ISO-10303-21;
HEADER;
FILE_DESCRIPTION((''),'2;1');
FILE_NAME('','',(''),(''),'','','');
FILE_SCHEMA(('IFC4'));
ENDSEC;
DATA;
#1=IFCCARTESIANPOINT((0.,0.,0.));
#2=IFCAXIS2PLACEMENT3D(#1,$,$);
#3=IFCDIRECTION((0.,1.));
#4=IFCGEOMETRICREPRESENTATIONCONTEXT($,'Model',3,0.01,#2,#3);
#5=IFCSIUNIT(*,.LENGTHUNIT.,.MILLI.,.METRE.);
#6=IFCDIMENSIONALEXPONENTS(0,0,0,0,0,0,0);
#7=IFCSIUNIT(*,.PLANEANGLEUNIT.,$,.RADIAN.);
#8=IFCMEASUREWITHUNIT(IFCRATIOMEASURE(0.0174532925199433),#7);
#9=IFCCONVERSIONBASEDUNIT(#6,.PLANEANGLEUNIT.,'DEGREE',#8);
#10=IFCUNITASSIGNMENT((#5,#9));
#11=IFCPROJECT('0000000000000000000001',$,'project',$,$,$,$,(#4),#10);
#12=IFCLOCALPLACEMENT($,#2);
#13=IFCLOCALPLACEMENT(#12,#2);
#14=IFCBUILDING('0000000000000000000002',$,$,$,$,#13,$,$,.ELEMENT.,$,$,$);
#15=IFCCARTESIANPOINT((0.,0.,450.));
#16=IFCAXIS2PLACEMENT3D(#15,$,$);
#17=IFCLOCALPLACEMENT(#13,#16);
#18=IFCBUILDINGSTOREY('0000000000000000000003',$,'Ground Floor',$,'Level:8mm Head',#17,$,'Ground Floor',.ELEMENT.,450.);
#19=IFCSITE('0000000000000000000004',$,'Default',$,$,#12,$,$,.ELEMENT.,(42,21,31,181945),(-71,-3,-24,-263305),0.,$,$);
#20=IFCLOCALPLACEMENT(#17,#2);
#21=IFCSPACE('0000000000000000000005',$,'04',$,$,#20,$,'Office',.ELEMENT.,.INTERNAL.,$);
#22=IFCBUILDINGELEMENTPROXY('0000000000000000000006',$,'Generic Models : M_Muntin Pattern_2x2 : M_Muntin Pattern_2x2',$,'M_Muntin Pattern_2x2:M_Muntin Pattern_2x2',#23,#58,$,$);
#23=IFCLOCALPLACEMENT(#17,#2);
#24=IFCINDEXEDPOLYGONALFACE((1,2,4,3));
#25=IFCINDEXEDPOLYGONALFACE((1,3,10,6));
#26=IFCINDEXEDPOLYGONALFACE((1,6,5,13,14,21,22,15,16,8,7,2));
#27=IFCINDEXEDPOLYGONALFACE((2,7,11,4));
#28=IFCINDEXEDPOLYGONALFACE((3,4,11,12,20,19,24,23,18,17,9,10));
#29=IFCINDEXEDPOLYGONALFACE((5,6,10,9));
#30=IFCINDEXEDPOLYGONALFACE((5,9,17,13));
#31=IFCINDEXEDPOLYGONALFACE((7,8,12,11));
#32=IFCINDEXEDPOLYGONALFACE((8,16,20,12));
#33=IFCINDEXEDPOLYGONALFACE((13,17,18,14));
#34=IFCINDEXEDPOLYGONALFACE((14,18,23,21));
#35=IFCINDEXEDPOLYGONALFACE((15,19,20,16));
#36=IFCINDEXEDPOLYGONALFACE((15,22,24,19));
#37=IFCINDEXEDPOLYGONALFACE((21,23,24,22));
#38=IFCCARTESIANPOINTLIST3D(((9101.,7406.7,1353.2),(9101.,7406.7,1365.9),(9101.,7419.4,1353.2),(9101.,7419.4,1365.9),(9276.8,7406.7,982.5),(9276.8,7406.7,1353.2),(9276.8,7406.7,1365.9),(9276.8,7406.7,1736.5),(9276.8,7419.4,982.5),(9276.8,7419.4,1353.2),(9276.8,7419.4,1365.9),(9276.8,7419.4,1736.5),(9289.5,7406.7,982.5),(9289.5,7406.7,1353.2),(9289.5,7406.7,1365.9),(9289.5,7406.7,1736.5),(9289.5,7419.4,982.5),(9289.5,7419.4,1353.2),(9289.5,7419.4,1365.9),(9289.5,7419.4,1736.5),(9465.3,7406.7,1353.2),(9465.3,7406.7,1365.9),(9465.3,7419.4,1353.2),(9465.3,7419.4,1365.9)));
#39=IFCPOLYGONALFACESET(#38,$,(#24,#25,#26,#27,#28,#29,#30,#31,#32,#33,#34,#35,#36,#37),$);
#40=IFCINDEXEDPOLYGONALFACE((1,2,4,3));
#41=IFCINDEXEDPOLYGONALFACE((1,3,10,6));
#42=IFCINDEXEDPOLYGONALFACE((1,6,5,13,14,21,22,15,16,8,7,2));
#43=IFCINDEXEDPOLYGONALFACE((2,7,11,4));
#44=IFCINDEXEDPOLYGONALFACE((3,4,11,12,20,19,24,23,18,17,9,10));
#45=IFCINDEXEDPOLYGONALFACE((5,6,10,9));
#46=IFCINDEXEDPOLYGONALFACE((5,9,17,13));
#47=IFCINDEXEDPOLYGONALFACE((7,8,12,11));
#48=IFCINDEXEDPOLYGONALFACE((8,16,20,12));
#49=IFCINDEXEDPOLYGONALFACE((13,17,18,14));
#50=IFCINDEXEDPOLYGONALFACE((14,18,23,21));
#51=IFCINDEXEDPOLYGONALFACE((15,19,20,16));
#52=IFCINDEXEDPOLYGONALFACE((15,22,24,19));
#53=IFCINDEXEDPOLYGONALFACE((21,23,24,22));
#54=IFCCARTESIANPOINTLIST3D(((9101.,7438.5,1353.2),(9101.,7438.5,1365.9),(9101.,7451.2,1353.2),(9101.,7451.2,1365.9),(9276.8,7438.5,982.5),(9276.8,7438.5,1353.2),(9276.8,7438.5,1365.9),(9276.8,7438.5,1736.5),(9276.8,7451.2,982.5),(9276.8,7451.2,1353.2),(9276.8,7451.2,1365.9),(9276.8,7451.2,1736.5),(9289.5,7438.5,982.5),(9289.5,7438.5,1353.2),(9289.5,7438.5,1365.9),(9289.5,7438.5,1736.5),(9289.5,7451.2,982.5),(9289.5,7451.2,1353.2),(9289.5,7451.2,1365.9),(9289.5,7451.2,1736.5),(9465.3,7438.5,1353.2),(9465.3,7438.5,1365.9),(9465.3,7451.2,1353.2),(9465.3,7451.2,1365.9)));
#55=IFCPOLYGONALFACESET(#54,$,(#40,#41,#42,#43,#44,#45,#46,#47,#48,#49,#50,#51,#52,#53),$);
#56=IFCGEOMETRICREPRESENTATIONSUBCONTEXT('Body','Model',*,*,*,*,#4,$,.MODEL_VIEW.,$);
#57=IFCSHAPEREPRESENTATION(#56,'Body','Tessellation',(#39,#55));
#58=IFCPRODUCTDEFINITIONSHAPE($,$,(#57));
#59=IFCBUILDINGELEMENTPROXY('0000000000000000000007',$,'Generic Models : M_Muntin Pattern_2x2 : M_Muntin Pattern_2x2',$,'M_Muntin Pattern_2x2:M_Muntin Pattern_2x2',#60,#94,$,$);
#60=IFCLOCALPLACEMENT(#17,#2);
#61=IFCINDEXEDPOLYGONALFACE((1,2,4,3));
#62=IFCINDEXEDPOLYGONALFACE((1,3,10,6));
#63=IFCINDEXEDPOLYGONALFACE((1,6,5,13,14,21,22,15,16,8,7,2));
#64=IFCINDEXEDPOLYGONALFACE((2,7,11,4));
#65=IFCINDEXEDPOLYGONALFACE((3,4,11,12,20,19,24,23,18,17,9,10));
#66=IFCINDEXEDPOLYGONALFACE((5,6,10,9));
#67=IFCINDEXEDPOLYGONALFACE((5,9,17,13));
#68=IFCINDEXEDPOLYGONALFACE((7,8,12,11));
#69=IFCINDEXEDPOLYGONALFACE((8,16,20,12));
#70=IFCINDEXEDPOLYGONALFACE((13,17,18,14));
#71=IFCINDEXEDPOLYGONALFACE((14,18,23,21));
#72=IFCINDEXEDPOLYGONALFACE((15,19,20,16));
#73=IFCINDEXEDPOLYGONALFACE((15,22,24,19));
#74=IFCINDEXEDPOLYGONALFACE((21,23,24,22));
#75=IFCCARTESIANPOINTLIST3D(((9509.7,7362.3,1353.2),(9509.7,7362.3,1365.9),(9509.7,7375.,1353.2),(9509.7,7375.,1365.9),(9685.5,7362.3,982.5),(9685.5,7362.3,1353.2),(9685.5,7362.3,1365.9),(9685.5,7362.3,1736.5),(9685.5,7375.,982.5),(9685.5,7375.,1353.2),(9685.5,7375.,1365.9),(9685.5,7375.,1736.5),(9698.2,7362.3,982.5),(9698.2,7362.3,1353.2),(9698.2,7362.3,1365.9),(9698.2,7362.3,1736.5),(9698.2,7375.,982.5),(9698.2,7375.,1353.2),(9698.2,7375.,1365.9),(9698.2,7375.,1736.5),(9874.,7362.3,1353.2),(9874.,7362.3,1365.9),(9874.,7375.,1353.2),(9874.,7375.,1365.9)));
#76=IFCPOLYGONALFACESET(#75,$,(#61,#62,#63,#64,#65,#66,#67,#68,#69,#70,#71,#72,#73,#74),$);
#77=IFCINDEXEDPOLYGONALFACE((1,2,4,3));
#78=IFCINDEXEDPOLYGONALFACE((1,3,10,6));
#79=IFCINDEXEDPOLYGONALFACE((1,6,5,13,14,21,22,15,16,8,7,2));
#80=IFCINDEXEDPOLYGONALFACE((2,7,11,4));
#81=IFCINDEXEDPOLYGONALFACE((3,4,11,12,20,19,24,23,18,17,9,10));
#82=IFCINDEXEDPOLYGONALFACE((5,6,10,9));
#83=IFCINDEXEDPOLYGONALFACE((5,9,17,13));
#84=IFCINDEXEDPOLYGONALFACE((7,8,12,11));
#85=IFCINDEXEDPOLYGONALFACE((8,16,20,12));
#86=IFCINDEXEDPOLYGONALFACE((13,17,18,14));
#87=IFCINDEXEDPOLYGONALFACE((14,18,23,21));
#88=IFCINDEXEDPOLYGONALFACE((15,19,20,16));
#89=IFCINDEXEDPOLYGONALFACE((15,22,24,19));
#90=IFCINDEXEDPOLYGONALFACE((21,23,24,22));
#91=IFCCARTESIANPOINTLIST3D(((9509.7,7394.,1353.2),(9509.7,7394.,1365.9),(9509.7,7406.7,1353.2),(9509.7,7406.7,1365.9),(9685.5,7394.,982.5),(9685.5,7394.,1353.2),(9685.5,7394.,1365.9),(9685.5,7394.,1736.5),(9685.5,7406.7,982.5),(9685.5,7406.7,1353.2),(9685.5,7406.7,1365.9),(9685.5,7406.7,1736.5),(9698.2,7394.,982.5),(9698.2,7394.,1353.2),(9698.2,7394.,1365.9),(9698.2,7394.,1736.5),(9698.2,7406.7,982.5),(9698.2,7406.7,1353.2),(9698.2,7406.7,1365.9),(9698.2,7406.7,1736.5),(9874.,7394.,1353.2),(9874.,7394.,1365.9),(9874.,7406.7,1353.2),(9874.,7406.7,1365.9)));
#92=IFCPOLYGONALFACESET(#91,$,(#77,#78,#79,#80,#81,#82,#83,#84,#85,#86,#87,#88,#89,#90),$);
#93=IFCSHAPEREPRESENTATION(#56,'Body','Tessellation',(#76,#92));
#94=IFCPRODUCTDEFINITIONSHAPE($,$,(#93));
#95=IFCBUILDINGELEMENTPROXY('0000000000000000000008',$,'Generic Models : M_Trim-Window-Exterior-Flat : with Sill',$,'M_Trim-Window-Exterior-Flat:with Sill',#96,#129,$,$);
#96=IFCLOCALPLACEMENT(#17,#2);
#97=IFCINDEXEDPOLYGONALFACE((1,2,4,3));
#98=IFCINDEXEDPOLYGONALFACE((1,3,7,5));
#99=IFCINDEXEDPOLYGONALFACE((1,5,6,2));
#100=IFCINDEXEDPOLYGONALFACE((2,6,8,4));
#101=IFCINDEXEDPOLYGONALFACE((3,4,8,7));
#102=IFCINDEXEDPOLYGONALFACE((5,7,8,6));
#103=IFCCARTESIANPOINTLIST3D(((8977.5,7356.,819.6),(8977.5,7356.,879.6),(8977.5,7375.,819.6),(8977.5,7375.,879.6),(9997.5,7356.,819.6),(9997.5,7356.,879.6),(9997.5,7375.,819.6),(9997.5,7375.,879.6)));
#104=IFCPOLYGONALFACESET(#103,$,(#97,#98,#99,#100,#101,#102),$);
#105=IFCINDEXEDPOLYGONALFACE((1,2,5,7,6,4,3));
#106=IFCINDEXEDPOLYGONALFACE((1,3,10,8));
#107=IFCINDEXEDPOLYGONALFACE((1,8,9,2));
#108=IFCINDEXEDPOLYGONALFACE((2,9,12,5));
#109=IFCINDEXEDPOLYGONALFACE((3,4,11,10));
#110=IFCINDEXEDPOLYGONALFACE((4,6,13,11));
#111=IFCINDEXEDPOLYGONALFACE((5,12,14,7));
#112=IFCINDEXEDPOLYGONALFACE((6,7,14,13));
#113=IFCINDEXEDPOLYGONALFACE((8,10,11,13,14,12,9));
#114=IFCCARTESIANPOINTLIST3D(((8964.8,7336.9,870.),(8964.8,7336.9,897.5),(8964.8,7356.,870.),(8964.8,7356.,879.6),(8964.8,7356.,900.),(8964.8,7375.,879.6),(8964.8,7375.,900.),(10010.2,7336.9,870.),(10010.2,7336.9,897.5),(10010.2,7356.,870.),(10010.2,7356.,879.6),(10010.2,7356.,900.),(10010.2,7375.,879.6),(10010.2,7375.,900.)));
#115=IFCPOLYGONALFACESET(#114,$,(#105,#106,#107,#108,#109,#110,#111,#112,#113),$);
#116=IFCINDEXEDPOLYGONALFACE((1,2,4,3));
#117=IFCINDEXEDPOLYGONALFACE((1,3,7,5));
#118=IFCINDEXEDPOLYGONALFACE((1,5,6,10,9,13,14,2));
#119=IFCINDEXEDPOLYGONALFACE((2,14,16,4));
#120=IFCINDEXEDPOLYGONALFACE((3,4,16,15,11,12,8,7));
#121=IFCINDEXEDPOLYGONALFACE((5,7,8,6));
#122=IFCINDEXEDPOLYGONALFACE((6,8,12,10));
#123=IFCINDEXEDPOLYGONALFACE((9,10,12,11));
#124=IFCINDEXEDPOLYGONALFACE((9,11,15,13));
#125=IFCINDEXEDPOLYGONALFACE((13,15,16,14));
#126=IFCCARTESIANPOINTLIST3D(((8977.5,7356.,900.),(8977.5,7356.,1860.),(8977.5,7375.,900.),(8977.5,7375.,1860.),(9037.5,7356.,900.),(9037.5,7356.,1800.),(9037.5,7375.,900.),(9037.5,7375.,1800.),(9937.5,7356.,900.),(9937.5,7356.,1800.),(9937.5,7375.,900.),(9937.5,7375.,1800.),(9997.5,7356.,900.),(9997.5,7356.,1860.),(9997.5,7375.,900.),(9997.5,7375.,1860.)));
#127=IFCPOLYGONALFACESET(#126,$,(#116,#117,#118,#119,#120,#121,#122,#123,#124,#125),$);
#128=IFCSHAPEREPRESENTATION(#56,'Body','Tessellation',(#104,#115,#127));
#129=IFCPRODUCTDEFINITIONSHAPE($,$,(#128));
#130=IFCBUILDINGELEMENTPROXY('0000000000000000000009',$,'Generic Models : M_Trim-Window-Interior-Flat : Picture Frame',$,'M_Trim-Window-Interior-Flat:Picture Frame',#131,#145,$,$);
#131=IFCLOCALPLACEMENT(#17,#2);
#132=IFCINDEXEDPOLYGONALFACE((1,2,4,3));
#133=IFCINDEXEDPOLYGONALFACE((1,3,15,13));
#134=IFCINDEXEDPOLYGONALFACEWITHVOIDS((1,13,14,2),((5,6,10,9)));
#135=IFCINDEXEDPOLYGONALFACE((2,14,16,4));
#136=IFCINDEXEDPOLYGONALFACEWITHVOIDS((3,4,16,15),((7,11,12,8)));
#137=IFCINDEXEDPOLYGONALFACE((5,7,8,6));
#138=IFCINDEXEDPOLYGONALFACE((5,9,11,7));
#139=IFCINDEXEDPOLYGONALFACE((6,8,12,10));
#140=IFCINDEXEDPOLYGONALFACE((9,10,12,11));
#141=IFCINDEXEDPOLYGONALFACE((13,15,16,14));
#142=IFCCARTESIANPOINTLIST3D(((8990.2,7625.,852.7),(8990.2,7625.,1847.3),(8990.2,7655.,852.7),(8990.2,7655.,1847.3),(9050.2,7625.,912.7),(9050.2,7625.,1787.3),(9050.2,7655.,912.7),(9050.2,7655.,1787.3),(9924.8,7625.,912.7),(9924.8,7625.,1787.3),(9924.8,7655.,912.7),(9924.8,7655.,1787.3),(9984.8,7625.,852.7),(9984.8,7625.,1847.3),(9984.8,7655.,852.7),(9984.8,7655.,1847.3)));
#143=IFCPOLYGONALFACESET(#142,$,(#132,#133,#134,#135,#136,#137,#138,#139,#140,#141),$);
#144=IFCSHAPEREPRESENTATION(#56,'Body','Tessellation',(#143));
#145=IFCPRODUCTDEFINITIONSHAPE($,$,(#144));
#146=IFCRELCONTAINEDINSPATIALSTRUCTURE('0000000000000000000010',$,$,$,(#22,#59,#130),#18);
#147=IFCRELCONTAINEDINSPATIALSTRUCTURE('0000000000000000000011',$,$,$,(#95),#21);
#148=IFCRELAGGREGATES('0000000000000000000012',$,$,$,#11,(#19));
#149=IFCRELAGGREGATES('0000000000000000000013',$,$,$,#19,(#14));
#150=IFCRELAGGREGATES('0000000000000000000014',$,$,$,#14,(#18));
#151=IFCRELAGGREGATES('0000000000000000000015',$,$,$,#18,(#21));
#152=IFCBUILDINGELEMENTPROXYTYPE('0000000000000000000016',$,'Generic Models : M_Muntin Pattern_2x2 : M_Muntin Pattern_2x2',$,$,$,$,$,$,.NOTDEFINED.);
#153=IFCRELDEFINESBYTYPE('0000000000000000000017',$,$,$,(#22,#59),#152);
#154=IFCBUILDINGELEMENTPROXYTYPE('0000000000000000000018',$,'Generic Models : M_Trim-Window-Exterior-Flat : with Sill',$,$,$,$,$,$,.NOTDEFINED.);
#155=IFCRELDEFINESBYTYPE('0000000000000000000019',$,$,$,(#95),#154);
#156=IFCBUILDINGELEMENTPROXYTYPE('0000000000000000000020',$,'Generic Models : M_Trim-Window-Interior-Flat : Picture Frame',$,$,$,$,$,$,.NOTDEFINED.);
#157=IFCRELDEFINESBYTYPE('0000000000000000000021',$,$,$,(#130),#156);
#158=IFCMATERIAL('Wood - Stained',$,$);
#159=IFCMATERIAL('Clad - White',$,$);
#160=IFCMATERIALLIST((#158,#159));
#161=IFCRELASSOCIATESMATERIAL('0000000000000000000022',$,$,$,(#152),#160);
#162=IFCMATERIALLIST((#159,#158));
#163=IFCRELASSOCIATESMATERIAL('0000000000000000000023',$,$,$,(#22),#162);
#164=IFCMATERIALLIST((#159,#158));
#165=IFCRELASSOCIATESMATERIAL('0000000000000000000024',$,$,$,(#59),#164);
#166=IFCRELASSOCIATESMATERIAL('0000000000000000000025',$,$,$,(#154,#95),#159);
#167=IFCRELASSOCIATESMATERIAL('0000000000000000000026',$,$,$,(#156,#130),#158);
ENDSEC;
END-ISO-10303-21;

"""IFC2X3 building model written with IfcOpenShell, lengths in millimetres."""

from ifc_helpers import new_model, entity, si_unit, converted_unit, direction, frame, frame_2d, origin, place, context, subcontext, project, spatial, polyline, rectangle, outline, extrude, source, transform, mapped, material, material_list, type_object, type_shapes, element, save


model = new_model("IFC2X3")

# Units and contexts
model_context = context("Model", 3, precision=0.01, world=origin(), true_north=direction((0.0, 1.0)))
body_context = subcontext(model_context, "Body", "Model", "MODEL_VIEW")
ifc_project = project(units=[si_unit("LENGTHUNIT", "METRE", prefix="MILLI"), converted_unit("PLANEANGLEUNIT", "DEGREE", entity("IfcRatioMeasure", 0.0174532925199433), si_unit("PLANEANGLEUNIT", "RADIAN"), dimensions=[0, 0, 0, 0, 0, 0, 0])], contexts=[model_context])

# Site, building, storey
site_placement = place(None, origin())
site = spatial("IfcSite", under=ifc_project, at=site_placement, Name="Default", CompositionType="ELEMENT", RefLatitude=(42, 21, 31, 181945), RefLongitude=(-71, -3, -24, -263305), RefElevation=0.0)
building_placement = place(site_placement, origin())
building = spatial("IfcBuilding", under=site, at=building_placement, CompositionType="ELEMENT")
storey_placement = place(building_placement, frame((0.0, 0.0, 450.0)))
storey = spatial("IfcBuildingStorey", under=building, at=storey_placement, Name="Ground Floor", ObjectType="Level:8mm Head", LongName="Ground Floor", CompositionType="ELEMENT", Elevation=450.0)

# Shared definitions
ifc_material_1 = material(Name="Clad - White")
ifc_material_2 = material(Name="Wood - Stained")

# Shared definitions
space_placement = place(storey_placement, origin())
space = spatial("IfcSpace", under=storey, at=space_placement, Name="04", LongName="Office", CompositionType="ELEMENT", InteriorOrExteriorSpace="INTERNAL")

# Building element proxies
ifc_material_list_1 = material_list([ifc_material_1, ifc_material_2])
ifc_material_list_2 = material_list([ifc_material_2, ifc_material_1])
building_element_proxy_type_1 = type_object("IfcBuildingElementProxyType", Name="Generic Models : M_Muntin Pattern_2x2 : M_Muntin Pattern_2x2", PredefinedType="NOTDEFINED", material=ifc_material_list_2)
shared_shape_1 = source(origin(), body_context, "Body", "SweptSolid", [
    extrude(outline(polyline([(6.4, -6.4), (377.0, -6.4), (377.0, 6.3), (6.4, 6.3), (6.4, 182.1), (-6.3, 182.1), (-6.3, 6.3), (-377.0, 6.3), (-377.0, -6.4), (-6.3, -6.4), (-6.3, -182.1), (6.4, -182.1), (6.4, -6.4)])), frame((0.0, 9.5, 377.0), z_axis=(0.0, 1.0, 0.0), x_axis=(0.0, 0.0, 1.0)), (0.0, 0.0, 1.0), 12.7),
    extrude(outline(polyline([(6.4, -6.4), (377.0, -6.4), (377.0, 6.3), (6.4, 6.3), (6.4, 182.1), (-6.3, 182.1), (-6.3, 6.3), (-377.0, 6.3), (-377.0, -6.4), (-6.3, -6.4), (-6.3, -182.1), (6.4, -182.1), (6.4, -6.4)])), frame((0.0, -22.2, 377.0), z_axis=(0.0, 1.0, 0.0), x_axis=(0.0, 0.0, 1.0)), (0.0, 0.0, 1.0), 12.7),
])
type_shapes(building_element_proxy_type_1, [shared_shape_1])
proxy_1_placement = place(storey_placement, frame((9283.1, 7429.0, 982.5), z_axis=(0.0, 0.0, 1.0), x_axis=(-1.0, 0.0, 0.0)))
element("IfcBuildingElementProxy", 1, at=proxy_1_placement, inside=storey, type_object=building_element_proxy_type_1, material=ifc_material_list_1, Name="Generic Models : M_Muntin Pattern_2x2 : M_Muntin Pattern_2x2", ObjectType="M_Muntin Pattern_2x2:M_Muntin Pattern_2x2", context=body_context, shape_type="MappedRepresentation", body=[
    mapped(shared_shape_1, transform((0.0, 0.0, 0.0), scale=1.0)),
])
ifc_material_list_3 = material_list([ifc_material_1, ifc_material_2])
proxy_2_placement = place(storey_placement, frame((9691.9, 7384.5, 982.5), z_axis=(0.0, 0.0, 1.0), x_axis=(-1.0, 0.0, 0.0)))
element("IfcBuildingElementProxy", 2, at=proxy_2_placement, inside=storey, type_object=building_element_proxy_type_1, material=ifc_material_list_3, Name="Generic Models : M_Muntin Pattern_2x2 : M_Muntin Pattern_2x2", ObjectType="M_Muntin Pattern_2x2:M_Muntin Pattern_2x2", context=body_context, shape_type="MappedRepresentation", body=[
    mapped(shared_shape_1, transform((0.0, 0.0, 0.0), scale=1.0)),
])
building_element_proxy_type_2 = type_object("IfcBuildingElementProxyType", Name="Generic Models : M_Trim-Window-Exterior-Flat : with Sill", PredefinedType="NOTDEFINED", material=ifc_material_1)
shared_shape_2 = source(origin(), body_context, "Body", "SweptSolid", [
    extrude(rectangle(XDim=1020.0, YDim=60.0, at=frame_2d((0.0, 0.0), x_axis=(1.0, 0.0))), frame((0.0, -950.4, 0.0), z_axis=(0.0, 0.0, 1.0), x_axis=(-1.0, 0.0, 0.0)), (0.0, 0.0, 1.0), 19.1),
    extrude(outline(polyline([(-19.0, -15.2), (0.0, -15.2), (0.0, -5.7), (19.0, -5.7), (19.0, 14.8), (0.0, 14.8), (-19.0, 12.3), (-19.0, -15.2)])), frame((-522.7, -914.8, 19.0), z_axis=(1.0, 0.0, 0.0), x_axis=(0.0, 0.0, -1.0)), (0.0, 0.0, 1.0), 1045.4),
    extrude(outline(polyline([(-495.0, -510.0), (465.0, -510.0), (465.0, -450.0), (-435.0, -450.0), (-435.0, 450.0), (465.0, 450.0), (465.0, 510.0), (-495.0, 510.0), (-495.0, -510.0)])), frame((0.0, -435.0, 0.0), z_axis=(0.0, 0.0, 1.0), x_axis=(0.0, -1.0, 0.0)), (0.0, 0.0, 1.0), 19.1),
])
type_shapes(building_element_proxy_type_2, [shared_shape_2])
proxy_3_placement = place(space_placement, frame((9487.5, 7375.0, 1800.0), z_axis=(0.0, -1.0, 0.0), x_axis=(1.0, 0.0, 0.0)))
element("IfcBuildingElementProxy", 3, at=proxy_3_placement, inside=space, type_object=building_element_proxy_type_2, material=ifc_material_1, Name="Generic Models : M_Trim-Window-Exterior-Flat : with Sill", ObjectType="M_Trim-Window-Exterior-Flat:with Sill", context=body_context, shape_type="MappedRepresentation", body=[
    mapped(shared_shape_2, transform((0.0, 0.0, 0.0), scale=1.0)),
])
building_element_proxy_type_3 = type_object("IfcBuildingElementProxyType", Name="Generic Models : M_Trim-Window-Interior-Flat : Picture Frame", PredefinedType="NOTDEFINED", material=ifc_material_2)
shared_shape_3 = source(origin(), body_context, "Body", "SweptSolid", [
    extrude(outline(polyline([(-497.3, -497.3), (497.3, -497.3), (497.3, 497.3), (-497.3, 497.3), (-497.3, -497.3)]), holes=[polyline([(-437.3, -437.3), (-437.3, 437.3), (437.3, 437.3), (437.3, -437.3), (-437.3, -437.3)])]), frame((0.0, -450.0, 0.0), z_axis=(0.0, 0.0, 1.0), x_axis=(-1.0, 0.0, 0.0)), (0.0, 0.0, 1.0), 30.0),
])
type_shapes(building_element_proxy_type_3, [shared_shape_3])
proxy_4_placement = place(storey_placement, frame((9487.5, 7625.0, 1800.0), z_axis=(0.0, 1.0, 0.0), x_axis=(-1.0, 0.0, 0.0)))
element("IfcBuildingElementProxy", 4, at=proxy_4_placement, inside=storey, type_object=building_element_proxy_type_3, material=ifc_material_2, Name="Generic Models : M_Trim-Window-Interior-Flat : Picture Frame", ObjectType="M_Trim-Window-Interior-Flat:Picture Frame", context=body_context, shape_type="MappedRepresentation", body=[
    mapped(shared_shape_3, transform((0.0, 0.0, 0.0), scale=1.0)),
])

save(model, "model.ifc")
